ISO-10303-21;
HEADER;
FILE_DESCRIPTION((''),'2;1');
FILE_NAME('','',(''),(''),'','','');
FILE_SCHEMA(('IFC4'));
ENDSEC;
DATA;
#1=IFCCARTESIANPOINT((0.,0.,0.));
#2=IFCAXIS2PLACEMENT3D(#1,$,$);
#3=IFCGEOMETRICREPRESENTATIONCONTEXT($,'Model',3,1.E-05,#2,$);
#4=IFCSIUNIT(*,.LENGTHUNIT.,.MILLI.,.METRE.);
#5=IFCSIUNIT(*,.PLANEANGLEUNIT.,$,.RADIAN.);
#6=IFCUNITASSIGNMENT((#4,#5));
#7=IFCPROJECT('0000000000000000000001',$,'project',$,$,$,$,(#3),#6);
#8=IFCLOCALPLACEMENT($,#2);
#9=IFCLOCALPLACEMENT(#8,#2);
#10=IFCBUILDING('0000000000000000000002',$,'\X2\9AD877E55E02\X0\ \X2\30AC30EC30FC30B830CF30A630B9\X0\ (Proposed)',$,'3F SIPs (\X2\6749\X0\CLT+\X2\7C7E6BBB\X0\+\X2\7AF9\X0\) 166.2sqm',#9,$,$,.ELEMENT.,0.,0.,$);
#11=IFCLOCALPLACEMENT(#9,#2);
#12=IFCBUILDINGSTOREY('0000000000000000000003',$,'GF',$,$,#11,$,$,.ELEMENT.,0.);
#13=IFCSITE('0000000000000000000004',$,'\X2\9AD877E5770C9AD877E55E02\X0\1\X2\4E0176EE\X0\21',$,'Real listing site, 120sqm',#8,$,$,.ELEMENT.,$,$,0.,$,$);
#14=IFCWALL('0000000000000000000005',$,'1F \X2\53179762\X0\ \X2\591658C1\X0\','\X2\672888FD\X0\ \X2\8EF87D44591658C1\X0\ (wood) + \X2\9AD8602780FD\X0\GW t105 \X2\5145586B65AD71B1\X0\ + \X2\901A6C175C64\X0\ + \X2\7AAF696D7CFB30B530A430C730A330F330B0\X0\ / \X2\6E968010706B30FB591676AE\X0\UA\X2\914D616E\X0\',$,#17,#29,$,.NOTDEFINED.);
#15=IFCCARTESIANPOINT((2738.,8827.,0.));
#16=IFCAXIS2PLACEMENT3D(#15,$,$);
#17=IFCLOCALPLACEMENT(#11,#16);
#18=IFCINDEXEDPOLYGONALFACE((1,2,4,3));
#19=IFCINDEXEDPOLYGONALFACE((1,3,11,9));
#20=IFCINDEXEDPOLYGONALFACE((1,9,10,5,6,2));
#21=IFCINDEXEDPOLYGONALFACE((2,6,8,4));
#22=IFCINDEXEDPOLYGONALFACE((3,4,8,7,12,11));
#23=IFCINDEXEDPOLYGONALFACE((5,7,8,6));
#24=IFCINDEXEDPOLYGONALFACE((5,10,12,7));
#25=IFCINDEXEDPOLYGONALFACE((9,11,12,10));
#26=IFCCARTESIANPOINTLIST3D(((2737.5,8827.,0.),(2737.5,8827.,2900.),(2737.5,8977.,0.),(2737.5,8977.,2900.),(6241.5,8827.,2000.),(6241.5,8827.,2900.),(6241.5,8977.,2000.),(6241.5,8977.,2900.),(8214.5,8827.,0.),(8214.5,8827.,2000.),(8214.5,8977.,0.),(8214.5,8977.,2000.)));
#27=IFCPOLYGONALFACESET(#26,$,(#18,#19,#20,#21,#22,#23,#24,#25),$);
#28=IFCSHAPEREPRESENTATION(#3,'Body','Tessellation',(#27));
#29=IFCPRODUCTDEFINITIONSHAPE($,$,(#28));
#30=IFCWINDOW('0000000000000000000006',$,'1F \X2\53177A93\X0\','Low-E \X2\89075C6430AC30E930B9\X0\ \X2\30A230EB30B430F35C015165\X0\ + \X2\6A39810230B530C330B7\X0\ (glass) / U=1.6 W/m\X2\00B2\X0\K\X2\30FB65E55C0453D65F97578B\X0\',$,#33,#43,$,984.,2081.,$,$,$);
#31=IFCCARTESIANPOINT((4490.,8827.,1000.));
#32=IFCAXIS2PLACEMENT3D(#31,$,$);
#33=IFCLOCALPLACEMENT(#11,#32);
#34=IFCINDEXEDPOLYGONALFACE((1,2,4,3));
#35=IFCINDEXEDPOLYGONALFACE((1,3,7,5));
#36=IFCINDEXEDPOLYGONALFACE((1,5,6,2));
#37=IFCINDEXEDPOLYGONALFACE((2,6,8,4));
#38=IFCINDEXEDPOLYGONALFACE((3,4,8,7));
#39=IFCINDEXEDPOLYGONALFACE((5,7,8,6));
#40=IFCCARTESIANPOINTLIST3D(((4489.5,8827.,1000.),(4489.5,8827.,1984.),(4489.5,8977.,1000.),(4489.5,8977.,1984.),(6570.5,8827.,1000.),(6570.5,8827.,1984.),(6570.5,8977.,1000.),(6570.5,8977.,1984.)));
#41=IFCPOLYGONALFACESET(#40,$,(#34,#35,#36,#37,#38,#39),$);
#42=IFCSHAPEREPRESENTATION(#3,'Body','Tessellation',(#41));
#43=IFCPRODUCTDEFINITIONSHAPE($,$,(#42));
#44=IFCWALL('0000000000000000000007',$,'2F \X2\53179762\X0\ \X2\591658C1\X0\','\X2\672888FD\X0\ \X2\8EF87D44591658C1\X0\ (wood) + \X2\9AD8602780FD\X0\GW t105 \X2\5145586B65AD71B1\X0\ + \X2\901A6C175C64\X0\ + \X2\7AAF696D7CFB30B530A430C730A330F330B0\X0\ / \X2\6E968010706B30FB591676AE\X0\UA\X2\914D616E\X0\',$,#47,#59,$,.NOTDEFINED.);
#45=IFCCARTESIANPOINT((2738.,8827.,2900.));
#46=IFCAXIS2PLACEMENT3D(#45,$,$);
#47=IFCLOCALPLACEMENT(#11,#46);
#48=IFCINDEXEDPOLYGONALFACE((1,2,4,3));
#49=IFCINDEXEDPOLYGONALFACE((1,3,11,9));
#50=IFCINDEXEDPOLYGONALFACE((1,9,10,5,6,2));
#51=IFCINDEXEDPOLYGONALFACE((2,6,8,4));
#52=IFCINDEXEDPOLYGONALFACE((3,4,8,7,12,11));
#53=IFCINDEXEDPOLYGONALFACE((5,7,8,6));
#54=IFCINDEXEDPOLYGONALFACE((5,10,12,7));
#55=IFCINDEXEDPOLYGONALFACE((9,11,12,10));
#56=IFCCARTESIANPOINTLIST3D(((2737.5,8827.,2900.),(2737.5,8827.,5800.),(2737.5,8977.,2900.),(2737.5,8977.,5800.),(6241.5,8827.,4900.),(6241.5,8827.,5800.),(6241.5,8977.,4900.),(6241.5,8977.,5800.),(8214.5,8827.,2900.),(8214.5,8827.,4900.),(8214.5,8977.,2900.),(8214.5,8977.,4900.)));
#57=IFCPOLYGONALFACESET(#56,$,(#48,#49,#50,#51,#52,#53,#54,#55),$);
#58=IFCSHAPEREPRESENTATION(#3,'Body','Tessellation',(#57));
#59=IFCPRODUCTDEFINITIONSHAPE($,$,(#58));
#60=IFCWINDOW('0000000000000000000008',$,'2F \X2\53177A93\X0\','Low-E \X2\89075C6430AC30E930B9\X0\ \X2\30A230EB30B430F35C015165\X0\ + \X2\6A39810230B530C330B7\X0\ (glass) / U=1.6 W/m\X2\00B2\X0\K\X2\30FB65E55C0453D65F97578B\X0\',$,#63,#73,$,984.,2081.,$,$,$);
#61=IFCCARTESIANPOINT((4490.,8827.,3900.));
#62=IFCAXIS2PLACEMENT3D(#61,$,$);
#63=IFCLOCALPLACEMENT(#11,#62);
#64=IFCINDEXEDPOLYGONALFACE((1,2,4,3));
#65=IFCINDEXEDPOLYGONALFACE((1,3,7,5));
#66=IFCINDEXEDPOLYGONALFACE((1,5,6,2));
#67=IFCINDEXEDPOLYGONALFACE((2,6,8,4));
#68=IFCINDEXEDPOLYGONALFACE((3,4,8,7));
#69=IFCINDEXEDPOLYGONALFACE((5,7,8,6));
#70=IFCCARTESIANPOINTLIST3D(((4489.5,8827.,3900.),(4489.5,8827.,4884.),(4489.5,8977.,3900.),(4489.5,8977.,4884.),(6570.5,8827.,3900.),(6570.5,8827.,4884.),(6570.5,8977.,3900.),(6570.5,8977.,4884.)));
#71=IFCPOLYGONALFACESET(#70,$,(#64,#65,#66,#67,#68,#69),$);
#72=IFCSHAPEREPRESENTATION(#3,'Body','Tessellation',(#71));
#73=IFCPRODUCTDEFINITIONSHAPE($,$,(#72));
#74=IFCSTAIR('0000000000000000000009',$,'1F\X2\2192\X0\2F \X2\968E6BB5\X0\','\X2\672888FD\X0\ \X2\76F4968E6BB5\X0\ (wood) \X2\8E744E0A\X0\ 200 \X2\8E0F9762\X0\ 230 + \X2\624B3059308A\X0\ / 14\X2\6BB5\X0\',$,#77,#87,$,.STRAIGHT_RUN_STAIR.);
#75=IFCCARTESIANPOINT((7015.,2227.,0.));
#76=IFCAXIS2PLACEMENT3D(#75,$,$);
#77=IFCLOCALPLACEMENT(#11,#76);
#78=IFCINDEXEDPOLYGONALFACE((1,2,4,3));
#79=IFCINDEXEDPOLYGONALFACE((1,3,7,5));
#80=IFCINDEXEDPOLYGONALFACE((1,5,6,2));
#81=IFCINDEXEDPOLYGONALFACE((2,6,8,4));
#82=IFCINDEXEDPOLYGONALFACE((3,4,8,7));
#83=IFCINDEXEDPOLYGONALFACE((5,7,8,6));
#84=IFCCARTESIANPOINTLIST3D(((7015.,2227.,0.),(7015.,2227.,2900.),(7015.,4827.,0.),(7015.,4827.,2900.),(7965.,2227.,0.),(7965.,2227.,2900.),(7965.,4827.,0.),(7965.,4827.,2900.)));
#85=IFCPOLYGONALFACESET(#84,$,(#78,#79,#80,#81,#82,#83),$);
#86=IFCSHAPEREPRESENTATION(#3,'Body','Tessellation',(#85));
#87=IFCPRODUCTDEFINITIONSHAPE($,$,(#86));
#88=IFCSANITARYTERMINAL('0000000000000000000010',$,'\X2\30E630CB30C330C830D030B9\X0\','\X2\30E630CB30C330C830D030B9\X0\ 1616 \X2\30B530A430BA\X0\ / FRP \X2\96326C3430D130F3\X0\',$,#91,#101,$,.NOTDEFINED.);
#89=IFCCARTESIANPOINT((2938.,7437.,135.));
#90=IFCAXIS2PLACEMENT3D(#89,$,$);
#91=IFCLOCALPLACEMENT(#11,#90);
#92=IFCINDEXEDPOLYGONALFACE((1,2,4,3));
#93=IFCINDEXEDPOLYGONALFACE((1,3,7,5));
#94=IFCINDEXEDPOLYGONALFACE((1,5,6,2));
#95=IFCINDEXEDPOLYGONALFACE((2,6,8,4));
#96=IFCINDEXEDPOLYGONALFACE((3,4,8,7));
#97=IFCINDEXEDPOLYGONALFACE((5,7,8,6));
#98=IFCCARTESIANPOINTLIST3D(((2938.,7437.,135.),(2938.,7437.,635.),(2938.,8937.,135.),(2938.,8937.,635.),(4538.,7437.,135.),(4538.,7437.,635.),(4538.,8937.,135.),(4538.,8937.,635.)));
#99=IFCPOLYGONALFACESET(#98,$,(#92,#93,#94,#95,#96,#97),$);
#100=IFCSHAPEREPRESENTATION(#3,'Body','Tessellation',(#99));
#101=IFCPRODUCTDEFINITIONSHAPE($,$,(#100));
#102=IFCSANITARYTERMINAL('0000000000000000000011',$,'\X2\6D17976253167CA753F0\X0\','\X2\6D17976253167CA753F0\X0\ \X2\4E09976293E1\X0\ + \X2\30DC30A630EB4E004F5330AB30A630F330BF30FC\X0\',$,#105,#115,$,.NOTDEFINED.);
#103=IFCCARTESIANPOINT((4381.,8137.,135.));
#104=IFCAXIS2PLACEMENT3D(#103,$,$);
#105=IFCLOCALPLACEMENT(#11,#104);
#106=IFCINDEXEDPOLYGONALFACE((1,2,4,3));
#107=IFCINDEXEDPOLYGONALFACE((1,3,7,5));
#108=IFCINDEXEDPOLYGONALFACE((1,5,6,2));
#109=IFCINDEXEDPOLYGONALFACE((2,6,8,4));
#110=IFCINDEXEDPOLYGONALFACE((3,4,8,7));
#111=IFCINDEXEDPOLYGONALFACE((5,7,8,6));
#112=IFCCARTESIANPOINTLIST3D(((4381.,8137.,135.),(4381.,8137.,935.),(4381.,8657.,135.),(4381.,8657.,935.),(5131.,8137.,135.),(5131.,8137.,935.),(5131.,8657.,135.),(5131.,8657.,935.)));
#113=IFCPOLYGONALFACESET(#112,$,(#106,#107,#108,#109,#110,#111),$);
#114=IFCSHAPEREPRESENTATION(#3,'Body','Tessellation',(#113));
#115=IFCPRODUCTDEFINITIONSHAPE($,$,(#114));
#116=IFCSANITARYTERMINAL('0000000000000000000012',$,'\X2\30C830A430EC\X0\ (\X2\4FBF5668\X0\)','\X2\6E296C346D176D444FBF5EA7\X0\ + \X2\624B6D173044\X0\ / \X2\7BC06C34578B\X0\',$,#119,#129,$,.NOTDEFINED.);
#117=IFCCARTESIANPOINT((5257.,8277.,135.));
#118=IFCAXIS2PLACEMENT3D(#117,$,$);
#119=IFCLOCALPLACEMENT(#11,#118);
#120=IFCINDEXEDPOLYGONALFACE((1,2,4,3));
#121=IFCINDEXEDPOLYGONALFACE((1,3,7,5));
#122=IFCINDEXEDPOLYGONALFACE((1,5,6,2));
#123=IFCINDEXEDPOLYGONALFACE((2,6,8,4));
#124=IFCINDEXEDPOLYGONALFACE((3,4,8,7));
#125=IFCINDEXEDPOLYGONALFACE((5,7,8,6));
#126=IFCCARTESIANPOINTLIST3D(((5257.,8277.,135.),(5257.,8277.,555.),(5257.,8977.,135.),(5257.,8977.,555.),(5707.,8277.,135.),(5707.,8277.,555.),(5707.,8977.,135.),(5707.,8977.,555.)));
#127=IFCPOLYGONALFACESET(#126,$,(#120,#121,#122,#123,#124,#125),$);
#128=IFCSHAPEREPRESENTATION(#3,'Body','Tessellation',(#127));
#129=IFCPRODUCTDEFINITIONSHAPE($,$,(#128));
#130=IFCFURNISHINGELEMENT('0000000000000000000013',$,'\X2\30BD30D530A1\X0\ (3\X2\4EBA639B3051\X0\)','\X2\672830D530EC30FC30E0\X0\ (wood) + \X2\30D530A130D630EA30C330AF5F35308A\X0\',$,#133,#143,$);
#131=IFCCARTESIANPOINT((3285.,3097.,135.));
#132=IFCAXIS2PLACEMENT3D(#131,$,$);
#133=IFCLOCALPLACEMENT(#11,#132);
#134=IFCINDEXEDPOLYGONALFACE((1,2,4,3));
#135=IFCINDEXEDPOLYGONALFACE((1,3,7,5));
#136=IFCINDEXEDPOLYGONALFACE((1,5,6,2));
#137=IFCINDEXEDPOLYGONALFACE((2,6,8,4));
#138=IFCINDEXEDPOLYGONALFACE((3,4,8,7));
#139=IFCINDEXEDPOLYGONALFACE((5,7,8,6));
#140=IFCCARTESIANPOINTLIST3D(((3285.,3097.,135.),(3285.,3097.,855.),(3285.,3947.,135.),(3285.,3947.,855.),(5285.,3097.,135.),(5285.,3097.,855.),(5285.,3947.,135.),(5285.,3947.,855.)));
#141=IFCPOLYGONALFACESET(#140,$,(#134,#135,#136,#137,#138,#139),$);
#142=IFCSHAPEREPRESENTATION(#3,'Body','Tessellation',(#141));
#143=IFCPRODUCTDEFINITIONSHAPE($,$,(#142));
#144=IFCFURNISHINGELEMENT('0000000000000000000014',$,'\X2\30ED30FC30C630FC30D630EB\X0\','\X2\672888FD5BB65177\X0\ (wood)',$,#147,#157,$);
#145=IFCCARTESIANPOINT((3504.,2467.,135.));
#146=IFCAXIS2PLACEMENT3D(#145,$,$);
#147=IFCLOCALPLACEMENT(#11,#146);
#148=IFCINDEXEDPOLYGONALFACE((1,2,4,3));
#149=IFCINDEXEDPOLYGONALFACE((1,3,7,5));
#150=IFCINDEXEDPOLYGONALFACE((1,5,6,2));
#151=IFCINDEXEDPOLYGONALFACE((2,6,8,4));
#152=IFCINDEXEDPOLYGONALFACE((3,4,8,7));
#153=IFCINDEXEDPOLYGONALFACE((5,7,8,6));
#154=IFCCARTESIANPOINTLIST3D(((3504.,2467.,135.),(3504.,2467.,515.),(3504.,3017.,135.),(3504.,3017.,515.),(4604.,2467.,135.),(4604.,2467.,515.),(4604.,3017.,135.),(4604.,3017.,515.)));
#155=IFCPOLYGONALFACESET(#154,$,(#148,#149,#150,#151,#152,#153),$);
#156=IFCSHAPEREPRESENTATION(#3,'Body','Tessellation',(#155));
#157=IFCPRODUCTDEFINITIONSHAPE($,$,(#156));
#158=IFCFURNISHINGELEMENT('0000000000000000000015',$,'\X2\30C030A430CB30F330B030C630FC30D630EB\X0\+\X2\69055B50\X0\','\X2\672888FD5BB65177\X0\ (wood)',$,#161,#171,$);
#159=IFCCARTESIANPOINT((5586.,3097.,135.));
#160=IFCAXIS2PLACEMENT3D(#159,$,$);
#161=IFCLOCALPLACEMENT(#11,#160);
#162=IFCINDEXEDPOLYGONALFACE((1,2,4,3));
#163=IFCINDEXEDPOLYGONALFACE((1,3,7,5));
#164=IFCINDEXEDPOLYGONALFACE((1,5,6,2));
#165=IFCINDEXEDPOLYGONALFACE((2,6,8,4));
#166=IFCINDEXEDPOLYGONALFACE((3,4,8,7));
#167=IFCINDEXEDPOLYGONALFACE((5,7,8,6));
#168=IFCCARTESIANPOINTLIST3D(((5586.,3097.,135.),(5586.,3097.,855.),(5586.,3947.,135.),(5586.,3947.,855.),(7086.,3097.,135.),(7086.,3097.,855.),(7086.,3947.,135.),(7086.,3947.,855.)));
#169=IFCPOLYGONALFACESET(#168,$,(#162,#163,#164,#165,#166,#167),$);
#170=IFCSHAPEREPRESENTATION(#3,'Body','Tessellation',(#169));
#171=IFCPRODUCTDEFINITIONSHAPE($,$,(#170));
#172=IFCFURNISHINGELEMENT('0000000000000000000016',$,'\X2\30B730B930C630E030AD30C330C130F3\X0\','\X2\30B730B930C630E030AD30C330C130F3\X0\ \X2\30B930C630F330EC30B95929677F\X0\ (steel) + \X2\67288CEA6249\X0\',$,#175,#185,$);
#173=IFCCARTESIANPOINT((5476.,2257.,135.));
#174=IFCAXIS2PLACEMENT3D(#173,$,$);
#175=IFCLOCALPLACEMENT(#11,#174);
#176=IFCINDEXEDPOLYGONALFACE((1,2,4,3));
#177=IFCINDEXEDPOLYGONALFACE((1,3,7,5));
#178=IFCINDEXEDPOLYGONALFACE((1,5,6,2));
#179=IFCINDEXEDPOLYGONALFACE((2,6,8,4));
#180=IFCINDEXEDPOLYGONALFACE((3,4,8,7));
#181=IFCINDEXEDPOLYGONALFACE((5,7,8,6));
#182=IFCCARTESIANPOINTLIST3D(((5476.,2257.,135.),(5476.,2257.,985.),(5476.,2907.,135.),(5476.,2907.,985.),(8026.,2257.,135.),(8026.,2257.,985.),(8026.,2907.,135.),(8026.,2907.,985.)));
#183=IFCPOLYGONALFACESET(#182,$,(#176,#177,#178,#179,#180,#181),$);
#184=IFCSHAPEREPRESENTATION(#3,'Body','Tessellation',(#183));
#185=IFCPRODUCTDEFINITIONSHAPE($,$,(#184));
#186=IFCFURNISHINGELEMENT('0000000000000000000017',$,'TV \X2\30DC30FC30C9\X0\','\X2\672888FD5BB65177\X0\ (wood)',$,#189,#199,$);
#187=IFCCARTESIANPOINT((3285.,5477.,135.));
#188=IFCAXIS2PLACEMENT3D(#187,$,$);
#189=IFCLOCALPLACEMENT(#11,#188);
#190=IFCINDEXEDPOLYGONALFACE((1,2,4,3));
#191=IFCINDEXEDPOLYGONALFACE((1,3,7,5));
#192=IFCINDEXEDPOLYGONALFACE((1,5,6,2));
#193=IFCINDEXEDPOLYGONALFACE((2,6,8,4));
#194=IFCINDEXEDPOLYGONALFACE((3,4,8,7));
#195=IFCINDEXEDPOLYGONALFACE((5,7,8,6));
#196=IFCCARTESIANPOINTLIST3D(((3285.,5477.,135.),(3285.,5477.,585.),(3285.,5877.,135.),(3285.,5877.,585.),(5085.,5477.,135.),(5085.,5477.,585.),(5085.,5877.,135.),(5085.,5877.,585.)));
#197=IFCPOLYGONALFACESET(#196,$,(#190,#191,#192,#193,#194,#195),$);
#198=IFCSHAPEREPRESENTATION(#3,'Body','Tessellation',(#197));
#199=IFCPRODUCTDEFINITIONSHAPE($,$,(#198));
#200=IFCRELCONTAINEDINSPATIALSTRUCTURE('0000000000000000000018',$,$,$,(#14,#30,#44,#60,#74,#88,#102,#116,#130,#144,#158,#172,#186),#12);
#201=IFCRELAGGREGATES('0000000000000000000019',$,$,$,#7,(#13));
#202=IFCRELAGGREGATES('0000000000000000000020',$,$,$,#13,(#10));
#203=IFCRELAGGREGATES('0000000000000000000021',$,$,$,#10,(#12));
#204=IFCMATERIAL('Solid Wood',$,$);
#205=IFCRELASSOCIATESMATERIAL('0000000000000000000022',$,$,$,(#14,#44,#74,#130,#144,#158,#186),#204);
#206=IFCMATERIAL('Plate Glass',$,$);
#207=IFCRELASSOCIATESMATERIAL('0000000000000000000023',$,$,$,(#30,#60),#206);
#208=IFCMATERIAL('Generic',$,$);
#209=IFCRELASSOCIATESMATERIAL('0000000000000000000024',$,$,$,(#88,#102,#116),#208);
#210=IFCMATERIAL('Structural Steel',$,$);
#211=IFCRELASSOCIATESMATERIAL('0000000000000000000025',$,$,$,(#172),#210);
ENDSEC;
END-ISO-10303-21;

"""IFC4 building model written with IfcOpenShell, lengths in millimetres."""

from ifc_helpers import new_model, si_unit, frame, frame_2d, origin, place, context, project, spatial, rectangle, extrude, material, element, fill, save


model = new_model("IFC4")

# Units and contexts
model_context = context("Model", 3, precision=1e-05, world=origin())
ifc_project = project(units=[si_unit("LENGTHUNIT", "METRE", prefix="MILLI"), si_unit("PLANEANGLEUNIT", "RADIAN")], contexts=[model_context])

# Site, building, storey
site_placement = place(None, origin())
site = spatial("IfcSite", under=ifc_project, at=site_placement, Name="高知県高知市1丁目21", ObjectType="Real listing site, 120sqm", CompositionType="ELEMENT", RefElevation=0.0)
building_placement = place(site_placement, origin())
building = spatial("IfcBuilding", under=site, at=building_placement, Name="高知市 ガレージハウス (Proposed)", ObjectType="3F SIPs (杉CLT+籾殻+竹) 166.2sqm", CompositionType="ELEMENT", ElevationOfRefHeight=0.0, ElevationOfTerrain=0.0)
storey_placement = place(building_placement, origin())
storey = spatial("IfcBuildingStorey", under=building, at=storey_placement, Name="GF", CompositionType="ELEMENT", Elevation=0.0)

# Wall, opening, window
ifc_material_1 = material(Name="Solid Wood")
wall_1_placement = place(storey_placement, frame((2738.0, 8827.0, 0.0)))
wall_1 = element("IfcWall", 1, at=wall_1_placement, inside=storey, material=ifc_material_1, Name="1F 北面 外壁", Description="木製 軸組外壁 (wood) + 高性能GW t105 充填断熱 + 通気層 + 窯業系サイディング / 準耐火・外皮UA配慮", PredefinedType="NOTDEFINED", context=model_context, shape_type="SweptSolid", body=[
    extrude(rectangle(XDim=5477.0, YDim=150.0, at=frame_2d((2738.0, 75.0))), frame((2738.0, 8827.0, 0.0)), (0.0, 0.0, 1.0), 2900.0),
])
opening_1_placement = place(storey_placement, frame((4490.0, 8827.0, 1000.0)))
opening_1 = element("IfcOpeningElement", 2, at=opening_1_placement, cuts=wall_1, PredefinedType="NOTDEFINED", context=model_context, shape_type="SweptSolid", body=[
    extrude(rectangle(XDim=2081.0, YDim=150.0, at=frame_2d((1040.0, 75.0))), frame((4490.0, 8827.0, 1000.0)), (0.0, 0.0, 1.0), 984.0),
])
ifc_material_2 = material(Name="Plate Glass")
window_1_placement = place(storey_placement, frame((4490.0, 8827.0, 1000.0)))
window_1 = element("IfcWindow", 3, at=window_1_placement, inside=storey, material=ifc_material_2, Name="1F 北窓", Description="Low-E 複層ガラス アルゴン封入 + 樹脂サッシ (glass) / U=1.6 W/m²K・日射取得型", OverallHeight=984.0, OverallWidth=2081.0, context=model_context, shape_type="SweptSolid", body=[
    extrude(rectangle(XDim=2081.0, YDim=150.0, at=frame_2d((1040.0, 75.0))), frame((4490.0, 8827.0, 1000.0)), (0.0, 0.0, 1.0), 984.0),
])
fill(opening_1, window_1)

# Wall, opening, window
wall_2_placement = place(storey_placement, frame((2738.0, 8827.0, 2900.0)))
wall_2 = element("IfcWall", 4, at=wall_2_placement, inside=storey, material=ifc_material_1, Name="2F 北面 外壁", Description="木製 軸組外壁 (wood) + 高性能GW t105 充填断熱 + 通気層 + 窯業系サイディング / 準耐火・外皮UA配慮", PredefinedType="NOTDEFINED", context=model_context, shape_type="SweptSolid", body=[
    extrude(rectangle(XDim=5477.0, YDim=150.0, at=frame_2d((2738.0, 75.0))), frame((2738.0, 8827.0, 2900.0)), (0.0, 0.0, 1.0), 2900.0),
])
opening_2_placement = place(storey_placement, frame((4490.0, 8827.0, 3900.0)))
opening_2 = element("IfcOpeningElement", 5, at=opening_2_placement, cuts=wall_2, PredefinedType="NOTDEFINED", context=model_context, shape_type="SweptSolid", body=[
    extrude(rectangle(XDim=2081.0, YDim=150.0, at=frame_2d((1040.0, 75.0))), frame((4490.0, 8827.0, 3900.0)), (0.0, 0.0, 1.0), 984.0),
])
window_2_placement = place(storey_placement, frame((4490.0, 8827.0, 3900.0)))
window_2 = element("IfcWindow", 6, at=window_2_placement, inside=storey, material=ifc_material_2, Name="2F 北窓", Description="Low-E 複層ガラス アルゴン封入 + 樹脂サッシ (glass) / U=1.6 W/m²K・日射取得型", OverallHeight=984.0, OverallWidth=2081.0, context=model_context, shape_type="SweptSolid", body=[
    extrude(rectangle(XDim=2081.0, YDim=150.0, at=frame_2d((1040.0, 75.0))), frame((4490.0, 8827.0, 3900.0)), (0.0, 0.0, 1.0), 984.0),
])
fill(opening_2, window_2)

# Stair
stair_placement = place(storey_placement, frame((7015.0, 2227.0, 0.0)))
element("IfcStair", 7, at=stair_placement, inside=storey, material=ifc_material_1, Name="1F→2F 階段", Description="木製 直階段 (wood) 蹴上 200 踏面 230 + 手すり / 14段", PredefinedType="STRAIGHT_RUN_STAIR", context=model_context, shape_type="SweptSolid", body=[
    extrude(rectangle(XDim=950.0, YDim=2600.0, at=frame_2d((475.0, 1300.0))), frame((7015.0, 2227.0, 0.0)), (0.0, 0.0, 1.0), 2900.0),
])

# Sanitary terminals
ifc_material_3 = material(Name="Generic")
sanitary_terminal_1_placement = place(storey_placement, frame((2938.0, 7437.0, 135.0)))
element("IfcSanitaryTerminal", 8, at=sanitary_terminal_1_placement, inside=storey, material=ifc_material_3, Name="ユニットバス", Description="ユニットバス 1616 サイズ / FRP 防水パン", PredefinedType="NOTDEFINED", context=model_context, shape_type="SweptSolid", body=[
    extrude(rectangle(XDim=1600.0, YDim=1500.0, at=frame_2d((800.0, 750.0))), frame((2938.0, 7437.0, 135.0)), (0.0, 0.0, 1.0), 500.0),
])
sanitary_terminal_2_placement = place(storey_placement, frame((4381.0, 8137.0, 135.0)))
element("IfcSanitaryTerminal", 9, at=sanitary_terminal_2_placement, inside=storey, material=ifc_material_3, Name="洗面化粧台", Description="洗面化粧台 三面鏡 + ボウル一体カウンター", PredefinedType="NOTDEFINED", context=model_context, shape_type="SweptSolid", body=[
    extrude(rectangle(XDim=750.0, YDim=520.0, at=frame_2d((375.0, 260.0))), frame((4381.0, 8137.0, 135.0)), (0.0, 0.0, 1.0), 800.0),
])
sanitary_terminal_3_placement = place(storey_placement, frame((5257.0, 8277.0, 135.0)))
element("IfcSanitaryTerminal", 10, at=sanitary_terminal_3_placement, inside=storey, material=ifc_material_3, Name="トイレ (便器)", Description="温水洗浄便座 + 手洗い / 節水型", PredefinedType="NOTDEFINED", context=model_context, shape_type="SweptSolid", body=[
    extrude(rectangle(XDim=450.0, YDim=700.0, at=frame_2d((225.0, 350.0))), frame((5257.0, 8277.0, 135.0)), (0.0, 0.0, 1.0), 420.0),
])

# Furnishing elements
furnishing_1_placement = place(storey_placement, frame((3285.0, 3097.0, 135.0)))
element("IfcFurnishingElement", 11, at=furnishing_1_placement, inside=storey, material=ifc_material_1, Name="ソファ (3人掛け)", Description="木フレーム (wood) + ファブリック張り", context=model_context, shape_type="SweptSolid", body=[
    extrude(rectangle(XDim=2000.0, YDim=850.0, at=frame_2d((1000.0, 425.0))), frame((3285.0, 3097.0, 135.0)), (0.0, 0.0, 1.0), 720.0),
])
furnishing_2_placement = place(storey_placement, frame((3504.0, 2467.0, 135.0)))
element("IfcFurnishingElement", 12, at=furnishing_2_placement, inside=storey, material=ifc_material_1, Name="ローテーブル", Description="木製家具 (wood)", context=model_context, shape_type="SweptSolid", body=[
    extrude(rectangle(XDim=1100.0, YDim=550.0, at=frame_2d((550.0, 275.0))), frame((3504.0, 2467.0, 135.0)), (0.0, 0.0, 1.0), 380.0),
])
furnishing_3_placement = place(storey_placement, frame((5586.0, 3097.0, 135.0)))
element("IfcFurnishingElement", 13, at=furnishing_3_placement, inside=storey, material=ifc_material_1, Name="ダイニングテーブル+椅子", Description="木製家具 (wood)", context=model_context, shape_type="SweptSolid", body=[
    extrude(rectangle(XDim=1500.0, YDim=850.0, at=frame_2d((750.0, 425.0))), frame((5586.0, 3097.0, 135.0)), (0.0, 0.0, 1.0), 720.0),
])
ifc_material_4 = material(Name="Structural Steel")
furnishing_4_placement = place(storey_placement, frame((5476.0, 2257.0, 135.0)))
element("IfcFurnishingElement", 14, at=furnishing_4_placement, inside=storey, material=ifc_material_4, Name="システムキッチン", Description="システムキッチン ステンレス天板 (steel) + 木質扉", context=model_context, shape_type="SweptSolid", body=[
    extrude(rectangle(XDim=2550.0, YDim=650.0, at=frame_2d((1275.0, 325.0))), frame((5476.0, 2257.0, 135.0)), (0.0, 0.0, 1.0), 850.0),
])
furnishing_5_placement = place(storey_placement, frame((3285.0, 5477.0, 135.0)))
element("IfcFurnishingElement", 15, at=furnishing_5_placement, inside=storey, material=ifc_material_1, Name="TV ボード", Description="木製家具 (wood)", context=model_context, shape_type="SweptSolid", body=[
    extrude(rectangle(XDim=1800.0, YDim=400.0, at=frame_2d((900.0, 200.0))), frame((3285.0, 5477.0, 135.0)), (0.0, 0.0, 1.0), 450.0),
])

save(model, "model.ifc")
